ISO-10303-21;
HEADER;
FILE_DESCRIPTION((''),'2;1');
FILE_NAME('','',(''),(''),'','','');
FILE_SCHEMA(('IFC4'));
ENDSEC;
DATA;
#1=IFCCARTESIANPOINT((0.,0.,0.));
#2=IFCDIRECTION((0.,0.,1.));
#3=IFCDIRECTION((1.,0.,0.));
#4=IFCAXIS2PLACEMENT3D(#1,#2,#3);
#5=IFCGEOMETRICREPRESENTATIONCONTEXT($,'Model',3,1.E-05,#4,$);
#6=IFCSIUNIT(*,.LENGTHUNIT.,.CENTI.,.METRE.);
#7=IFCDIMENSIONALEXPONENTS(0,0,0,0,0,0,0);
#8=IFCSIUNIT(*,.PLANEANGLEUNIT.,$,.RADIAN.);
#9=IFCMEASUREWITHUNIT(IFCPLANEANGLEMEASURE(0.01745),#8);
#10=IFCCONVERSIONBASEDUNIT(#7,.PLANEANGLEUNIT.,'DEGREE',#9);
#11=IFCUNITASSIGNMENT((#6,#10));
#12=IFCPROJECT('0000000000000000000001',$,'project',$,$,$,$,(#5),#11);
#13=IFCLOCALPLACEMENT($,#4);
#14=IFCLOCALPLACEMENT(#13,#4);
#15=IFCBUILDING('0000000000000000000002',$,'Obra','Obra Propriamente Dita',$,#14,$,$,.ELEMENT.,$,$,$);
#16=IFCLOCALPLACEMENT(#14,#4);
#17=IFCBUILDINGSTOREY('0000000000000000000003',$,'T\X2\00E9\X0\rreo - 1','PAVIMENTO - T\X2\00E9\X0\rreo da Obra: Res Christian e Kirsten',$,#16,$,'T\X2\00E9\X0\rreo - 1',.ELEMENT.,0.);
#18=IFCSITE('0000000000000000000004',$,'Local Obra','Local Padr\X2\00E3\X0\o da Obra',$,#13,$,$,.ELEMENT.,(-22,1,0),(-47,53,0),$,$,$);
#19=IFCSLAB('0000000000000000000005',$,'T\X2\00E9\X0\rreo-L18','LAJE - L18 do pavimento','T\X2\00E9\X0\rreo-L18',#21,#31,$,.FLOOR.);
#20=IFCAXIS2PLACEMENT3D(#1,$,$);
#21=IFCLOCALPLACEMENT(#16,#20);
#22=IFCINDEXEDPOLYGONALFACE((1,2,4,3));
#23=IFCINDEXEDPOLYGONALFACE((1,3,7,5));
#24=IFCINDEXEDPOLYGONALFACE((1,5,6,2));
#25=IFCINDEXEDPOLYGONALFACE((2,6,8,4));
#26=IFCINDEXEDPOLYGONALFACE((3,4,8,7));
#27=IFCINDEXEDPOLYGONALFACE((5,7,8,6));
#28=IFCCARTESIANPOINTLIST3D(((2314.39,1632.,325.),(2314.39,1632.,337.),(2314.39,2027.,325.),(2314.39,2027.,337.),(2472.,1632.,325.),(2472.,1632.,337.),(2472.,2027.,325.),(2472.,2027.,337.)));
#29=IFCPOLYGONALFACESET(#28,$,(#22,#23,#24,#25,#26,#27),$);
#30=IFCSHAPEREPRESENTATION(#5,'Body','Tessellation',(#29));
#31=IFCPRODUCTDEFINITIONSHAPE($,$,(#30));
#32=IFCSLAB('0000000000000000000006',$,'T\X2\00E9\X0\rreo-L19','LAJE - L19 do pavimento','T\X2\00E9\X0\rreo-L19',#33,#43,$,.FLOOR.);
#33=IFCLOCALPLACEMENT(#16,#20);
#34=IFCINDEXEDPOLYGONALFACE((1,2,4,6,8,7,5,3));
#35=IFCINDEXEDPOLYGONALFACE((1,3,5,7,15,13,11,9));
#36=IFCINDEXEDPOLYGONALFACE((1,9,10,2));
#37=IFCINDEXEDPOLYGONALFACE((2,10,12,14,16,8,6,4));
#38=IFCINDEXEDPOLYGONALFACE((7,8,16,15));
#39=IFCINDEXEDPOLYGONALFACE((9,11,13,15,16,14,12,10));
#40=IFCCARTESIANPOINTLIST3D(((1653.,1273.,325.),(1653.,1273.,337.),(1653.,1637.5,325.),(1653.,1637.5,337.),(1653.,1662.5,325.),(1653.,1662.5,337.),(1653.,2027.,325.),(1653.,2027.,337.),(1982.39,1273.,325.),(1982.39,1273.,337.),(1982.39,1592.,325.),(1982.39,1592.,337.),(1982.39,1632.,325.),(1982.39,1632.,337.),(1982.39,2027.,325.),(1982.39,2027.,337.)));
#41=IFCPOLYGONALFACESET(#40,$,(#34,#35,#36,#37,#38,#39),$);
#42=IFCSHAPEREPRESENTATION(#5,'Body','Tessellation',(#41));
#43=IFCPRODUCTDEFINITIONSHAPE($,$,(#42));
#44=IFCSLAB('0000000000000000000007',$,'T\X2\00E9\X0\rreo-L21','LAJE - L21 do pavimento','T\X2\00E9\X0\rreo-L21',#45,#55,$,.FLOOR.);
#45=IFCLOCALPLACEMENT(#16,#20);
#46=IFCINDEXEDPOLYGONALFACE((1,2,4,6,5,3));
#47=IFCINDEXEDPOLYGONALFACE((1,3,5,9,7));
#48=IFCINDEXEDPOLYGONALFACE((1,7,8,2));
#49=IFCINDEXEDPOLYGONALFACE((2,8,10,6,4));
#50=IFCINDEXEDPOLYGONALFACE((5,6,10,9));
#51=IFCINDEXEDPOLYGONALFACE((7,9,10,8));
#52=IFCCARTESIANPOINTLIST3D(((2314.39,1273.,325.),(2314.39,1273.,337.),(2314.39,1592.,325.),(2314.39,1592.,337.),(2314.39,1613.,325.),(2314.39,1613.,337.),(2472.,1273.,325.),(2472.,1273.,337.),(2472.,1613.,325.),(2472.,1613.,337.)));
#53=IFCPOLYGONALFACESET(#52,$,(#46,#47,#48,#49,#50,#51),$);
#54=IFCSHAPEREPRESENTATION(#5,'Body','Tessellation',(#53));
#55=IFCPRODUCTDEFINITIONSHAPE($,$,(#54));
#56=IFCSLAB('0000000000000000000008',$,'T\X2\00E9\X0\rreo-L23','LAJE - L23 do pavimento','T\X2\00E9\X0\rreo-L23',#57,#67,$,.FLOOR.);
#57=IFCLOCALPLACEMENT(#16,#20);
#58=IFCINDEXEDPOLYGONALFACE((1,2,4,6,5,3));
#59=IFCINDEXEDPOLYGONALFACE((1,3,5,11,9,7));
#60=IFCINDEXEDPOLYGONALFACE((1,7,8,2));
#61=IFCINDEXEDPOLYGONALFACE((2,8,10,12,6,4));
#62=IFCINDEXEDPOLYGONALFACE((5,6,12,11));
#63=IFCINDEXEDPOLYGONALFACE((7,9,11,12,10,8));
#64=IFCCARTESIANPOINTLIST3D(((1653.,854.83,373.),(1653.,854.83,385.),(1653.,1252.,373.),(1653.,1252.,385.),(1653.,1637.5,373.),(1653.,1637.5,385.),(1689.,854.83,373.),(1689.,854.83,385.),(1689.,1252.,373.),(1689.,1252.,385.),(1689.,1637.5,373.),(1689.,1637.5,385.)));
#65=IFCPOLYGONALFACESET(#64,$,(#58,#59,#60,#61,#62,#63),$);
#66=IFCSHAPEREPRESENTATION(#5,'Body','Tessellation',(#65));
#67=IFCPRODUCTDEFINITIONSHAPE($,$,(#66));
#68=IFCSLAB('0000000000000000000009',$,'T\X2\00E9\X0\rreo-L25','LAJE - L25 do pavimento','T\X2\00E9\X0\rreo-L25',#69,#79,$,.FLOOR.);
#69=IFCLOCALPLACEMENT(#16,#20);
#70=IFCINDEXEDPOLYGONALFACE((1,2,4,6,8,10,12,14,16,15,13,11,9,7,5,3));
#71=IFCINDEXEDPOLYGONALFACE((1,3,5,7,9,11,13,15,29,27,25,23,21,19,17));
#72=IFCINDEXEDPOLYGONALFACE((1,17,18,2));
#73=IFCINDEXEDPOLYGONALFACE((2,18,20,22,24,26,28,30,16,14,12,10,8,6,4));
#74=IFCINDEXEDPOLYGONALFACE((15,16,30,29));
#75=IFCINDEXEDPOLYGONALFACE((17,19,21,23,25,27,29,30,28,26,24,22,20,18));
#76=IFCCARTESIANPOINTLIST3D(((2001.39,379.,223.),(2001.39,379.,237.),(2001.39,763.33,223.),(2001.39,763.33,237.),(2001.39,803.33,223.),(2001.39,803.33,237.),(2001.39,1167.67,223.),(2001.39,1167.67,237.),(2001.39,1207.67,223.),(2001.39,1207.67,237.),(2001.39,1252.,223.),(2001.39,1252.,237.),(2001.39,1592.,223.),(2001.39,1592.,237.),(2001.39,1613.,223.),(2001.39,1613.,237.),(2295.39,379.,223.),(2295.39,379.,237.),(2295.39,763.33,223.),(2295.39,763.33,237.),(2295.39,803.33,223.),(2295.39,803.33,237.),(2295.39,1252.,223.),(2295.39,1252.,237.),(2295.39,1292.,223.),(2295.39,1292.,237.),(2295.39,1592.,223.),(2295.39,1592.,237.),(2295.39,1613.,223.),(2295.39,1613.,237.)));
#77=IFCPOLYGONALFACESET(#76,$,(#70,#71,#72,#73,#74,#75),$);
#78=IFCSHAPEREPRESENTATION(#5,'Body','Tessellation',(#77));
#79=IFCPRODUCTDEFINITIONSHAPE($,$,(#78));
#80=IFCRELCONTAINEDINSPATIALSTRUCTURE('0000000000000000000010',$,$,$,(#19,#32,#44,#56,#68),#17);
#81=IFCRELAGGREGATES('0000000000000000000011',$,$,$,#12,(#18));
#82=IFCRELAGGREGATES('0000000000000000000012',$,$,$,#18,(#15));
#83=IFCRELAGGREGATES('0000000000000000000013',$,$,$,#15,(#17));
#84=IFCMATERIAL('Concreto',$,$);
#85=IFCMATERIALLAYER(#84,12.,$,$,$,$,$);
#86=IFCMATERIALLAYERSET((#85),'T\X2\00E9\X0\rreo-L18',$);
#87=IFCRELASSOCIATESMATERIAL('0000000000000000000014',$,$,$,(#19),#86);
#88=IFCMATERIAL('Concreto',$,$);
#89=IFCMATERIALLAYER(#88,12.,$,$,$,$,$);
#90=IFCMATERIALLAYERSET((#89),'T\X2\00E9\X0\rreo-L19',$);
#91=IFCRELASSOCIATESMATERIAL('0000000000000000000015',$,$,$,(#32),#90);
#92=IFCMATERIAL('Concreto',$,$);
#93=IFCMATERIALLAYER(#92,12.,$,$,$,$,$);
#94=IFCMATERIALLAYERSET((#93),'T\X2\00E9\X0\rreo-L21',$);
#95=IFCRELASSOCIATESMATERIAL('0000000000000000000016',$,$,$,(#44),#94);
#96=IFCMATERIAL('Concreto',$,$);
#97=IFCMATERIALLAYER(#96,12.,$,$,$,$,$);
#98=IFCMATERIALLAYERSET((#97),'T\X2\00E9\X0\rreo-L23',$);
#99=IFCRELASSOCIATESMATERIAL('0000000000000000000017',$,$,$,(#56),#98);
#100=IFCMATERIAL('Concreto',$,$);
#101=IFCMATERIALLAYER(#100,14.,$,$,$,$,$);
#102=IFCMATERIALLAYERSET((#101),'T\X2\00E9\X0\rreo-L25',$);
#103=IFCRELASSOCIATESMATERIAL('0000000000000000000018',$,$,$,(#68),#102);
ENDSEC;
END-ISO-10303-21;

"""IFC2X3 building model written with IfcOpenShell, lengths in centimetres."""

from ifc_helpers import new_model, entity, si_unit, converted_unit, frame, origin_with_axes, place, context, project, spatial, polyline, outline, extrude, material, layer, layer_set, layer_usage, element, save


model = new_model("IFC2X3")

# Units and contexts
model_context = context("Model", 3, precision=1e-05, world=origin_with_axes())
ifc_project = project(units=[si_unit("LENGTHUNIT", "METRE", prefix="CENTI"), converted_unit("PLANEANGLEUNIT", "DEGREE", entity("IfcPlaneAngleMeasure", 0.01745), si_unit("PLANEANGLEUNIT", "RADIAN"), dimensions=[0, 0, 0, 0, 0, 0, 0])], contexts=[model_context])

# Site, building, storey
site_placement = place(None, origin_with_axes())
site = spatial("IfcSite", under=ifc_project, at=site_placement, Name="Local Obra", Description="Local Padrão da Obra", CompositionType="ELEMENT", RefLatitude=(-22, 1, 0), RefLongitude=(-47, 53, 0))
building_placement = place(site_placement, origin_with_axes())
building = spatial("IfcBuilding", under=site, at=building_placement, Name="Obra", Description="Obra Propriamente Dita", CompositionType="ELEMENT")
storey_placement = place(building_placement, origin_with_axes())
storey = spatial("IfcBuildingStorey", under=building, at=storey_placement, Name="Térreo - 1", Description="PAVIMENTO - Térreo da Obra: Res Christian e Kirsten", LongName="Térreo - 1", CompositionType="ELEMENT", Elevation=0.0)

# Slabs
ifc_material_1 = material(Name="Concreto")
ifc_layer_1 = layer(ifc_material_1, 12.0)
ifc_layer_set_1 = layer_set([ifc_layer_1], Name="Térreo-L18")
ifc_layer_usage_1 = layer_usage(ifc_layer_set_1, "AXIS3", "POSITIVE", 0.0)
slab_1_placement = place(storey_placement, frame((2472.0, 1632.0, 325.0), z_axis=(0.0, 0.0, 1.0), x_axis=(1.0, 0.0, 0.0)))
element("IfcSlab", 1, at=slab_1_placement, inside=storey, material=ifc_layer_usage_1, Name="Térreo-L18", Description="LAJE - L18 do pavimento", ObjectType="Térreo-L18", PredefinedType="FLOOR", context=model_context, shape_type="SweptSolid", body=[
    extrude(outline(polyline([(0.0, 395.0), (-157.61, 395.0), (-157.61, 0.0), (0.0, 0.0), (0.0, 395.0)])), origin_with_axes(), (0.0, 0.0, 1.0), 12.0),
])
ifc_material_2 = material(Name="Concreto")
ifc_layer_2 = layer(ifc_material_2, 12.0)
ifc_layer_set_2 = layer_set([ifc_layer_2], Name="Térreo-L19")
ifc_layer_usage_2 = layer_usage(ifc_layer_set_2, "AXIS3", "POSITIVE", 0.0)
slab_2_placement = place(storey_placement, frame((1982.39, 1632.0, 325.0), z_axis=(0.0, 0.0, 1.0), x_axis=(1.0, 0.0, 0.0)))
element("IfcSlab", 2, at=slab_2_placement, inside=storey, material=ifc_layer_usage_2, Name="Térreo-L19", Description="LAJE - L19 do pavimento", ObjectType="Térreo-L19", PredefinedType="FLOOR", context=model_context, shape_type="SweptSolid", body=[
    extrude(outline(polyline([(0.0, 395.0), (-329.39, 395.0), (-329.39, 30.5), (-329.39, 5.5), (-329.39, -359.0), (0.0, -359.0), (0.0, -40.0), (0.0, 0.0), (0.0, 395.0)])), origin_with_axes(), (0.0, 0.0, 1.0), 12.0),
])
ifc_material_3 = material(Name="Concreto")
ifc_layer_3 = layer(ifc_material_3, 12.0)
ifc_layer_set_3 = layer_set([ifc_layer_3], Name="Térreo-L21")
ifc_layer_usage_3 = layer_usage(ifc_layer_set_3, "AXIS3", "POSITIVE", 0.0)
slab_3_placement = place(storey_placement, frame((2472.0, 1273.0, 325.0), z_axis=(0.0, 0.0, 1.0), x_axis=(1.0, 0.0, 0.0)))
element("IfcSlab", 3, at=slab_3_placement, inside=storey, material=ifc_layer_usage_3, Name="Térreo-L21", Description="LAJE - L21 do pavimento", ObjectType="Térreo-L21", PredefinedType="FLOOR", context=model_context, shape_type="SweptSolid", body=[
    extrude(outline(polyline([(0.0, 340.0), (-157.61, 340.0), (-157.61, 319.0), (-157.61, 0.0), (0.0, 0.0), (0.0, 340.0)])), origin_with_axes(), (0.0, 0.0, 1.0), 12.0),
])
ifc_material_4 = material(Name="Concreto")
ifc_layer_4 = layer(ifc_material_4, 12.0)
ifc_layer_set_4 = layer_set([ifc_layer_4], Name="Térreo-L23")
ifc_layer_usage_4 = layer_usage(ifc_layer_set_4, "AXIS3", "POSITIVE", 0.0)
slab_4_placement = place(storey_placement, frame((1689.0, 1252.0, 373.0), z_axis=(0.0, 0.0, 1.0), x_axis=(1.0, 0.0, 0.0)))
element("IfcSlab", 4, at=slab_4_placement, inside=storey, material=ifc_layer_usage_4, Name="Térreo-L23", Description="LAJE - L23 do pavimento", ObjectType="Térreo-L23", PredefinedType="FLOOR", context=model_context, shape_type="SweptSolid", body=[
    extrude(outline(polyline([(0.0, 385.5), (-36.0, 385.5), (-36.0, 0.0), (-36.0, -397.17), (0.0, -397.17), (0.0, 0.0), (0.0, 385.5)])), origin_with_axes(), (0.0, 0.0, 1.0), 12.0),
])
ifc_material_5 = material(Name="Concreto")
ifc_layer_5 = layer(ifc_material_5, 14.0)
ifc_layer_set_5 = layer_set([ifc_layer_5], Name="Térreo-L25")
ifc_layer_usage_5 = layer_usage(ifc_layer_set_5, "AXIS3", "POSITIVE", 0.0)
slab_5_placement = place(storey_placement, frame((2295.39, 1592.0, 223.0), z_axis=(0.0, 0.0, 1.0), x_axis=(1.0, 0.0, 0.0)))
element("IfcSlab", 5, at=slab_5_placement, inside=storey, material=ifc_layer_usage_5, Name="Térreo-L25", Description="LAJE - L25 do pavimento", ObjectType="Térreo-L25", PredefinedType="FLOOR", context=model_context, shape_type="SweptSolid", body=[
    extrude(outline(polyline([(0.0, 21.0), (-294.0, 21.0), (-294.0, 0.0), (-294.0, -340.0), (-294.0, -384.33), (-294.0, -424.33), (-294.0, -788.67), (-294.0, -828.67), (-294.0, -1213.0), (0.0, -1213.0), (0.0, -828.67), (0.0, -788.67), (0.0, -340.0), (0.0, -300.0), (0.0, 0.0), (0.0, 21.0)])), origin_with_axes(), (0.0, 0.0, 1.0), 14.0),
])

save(model, "model.ifc")
